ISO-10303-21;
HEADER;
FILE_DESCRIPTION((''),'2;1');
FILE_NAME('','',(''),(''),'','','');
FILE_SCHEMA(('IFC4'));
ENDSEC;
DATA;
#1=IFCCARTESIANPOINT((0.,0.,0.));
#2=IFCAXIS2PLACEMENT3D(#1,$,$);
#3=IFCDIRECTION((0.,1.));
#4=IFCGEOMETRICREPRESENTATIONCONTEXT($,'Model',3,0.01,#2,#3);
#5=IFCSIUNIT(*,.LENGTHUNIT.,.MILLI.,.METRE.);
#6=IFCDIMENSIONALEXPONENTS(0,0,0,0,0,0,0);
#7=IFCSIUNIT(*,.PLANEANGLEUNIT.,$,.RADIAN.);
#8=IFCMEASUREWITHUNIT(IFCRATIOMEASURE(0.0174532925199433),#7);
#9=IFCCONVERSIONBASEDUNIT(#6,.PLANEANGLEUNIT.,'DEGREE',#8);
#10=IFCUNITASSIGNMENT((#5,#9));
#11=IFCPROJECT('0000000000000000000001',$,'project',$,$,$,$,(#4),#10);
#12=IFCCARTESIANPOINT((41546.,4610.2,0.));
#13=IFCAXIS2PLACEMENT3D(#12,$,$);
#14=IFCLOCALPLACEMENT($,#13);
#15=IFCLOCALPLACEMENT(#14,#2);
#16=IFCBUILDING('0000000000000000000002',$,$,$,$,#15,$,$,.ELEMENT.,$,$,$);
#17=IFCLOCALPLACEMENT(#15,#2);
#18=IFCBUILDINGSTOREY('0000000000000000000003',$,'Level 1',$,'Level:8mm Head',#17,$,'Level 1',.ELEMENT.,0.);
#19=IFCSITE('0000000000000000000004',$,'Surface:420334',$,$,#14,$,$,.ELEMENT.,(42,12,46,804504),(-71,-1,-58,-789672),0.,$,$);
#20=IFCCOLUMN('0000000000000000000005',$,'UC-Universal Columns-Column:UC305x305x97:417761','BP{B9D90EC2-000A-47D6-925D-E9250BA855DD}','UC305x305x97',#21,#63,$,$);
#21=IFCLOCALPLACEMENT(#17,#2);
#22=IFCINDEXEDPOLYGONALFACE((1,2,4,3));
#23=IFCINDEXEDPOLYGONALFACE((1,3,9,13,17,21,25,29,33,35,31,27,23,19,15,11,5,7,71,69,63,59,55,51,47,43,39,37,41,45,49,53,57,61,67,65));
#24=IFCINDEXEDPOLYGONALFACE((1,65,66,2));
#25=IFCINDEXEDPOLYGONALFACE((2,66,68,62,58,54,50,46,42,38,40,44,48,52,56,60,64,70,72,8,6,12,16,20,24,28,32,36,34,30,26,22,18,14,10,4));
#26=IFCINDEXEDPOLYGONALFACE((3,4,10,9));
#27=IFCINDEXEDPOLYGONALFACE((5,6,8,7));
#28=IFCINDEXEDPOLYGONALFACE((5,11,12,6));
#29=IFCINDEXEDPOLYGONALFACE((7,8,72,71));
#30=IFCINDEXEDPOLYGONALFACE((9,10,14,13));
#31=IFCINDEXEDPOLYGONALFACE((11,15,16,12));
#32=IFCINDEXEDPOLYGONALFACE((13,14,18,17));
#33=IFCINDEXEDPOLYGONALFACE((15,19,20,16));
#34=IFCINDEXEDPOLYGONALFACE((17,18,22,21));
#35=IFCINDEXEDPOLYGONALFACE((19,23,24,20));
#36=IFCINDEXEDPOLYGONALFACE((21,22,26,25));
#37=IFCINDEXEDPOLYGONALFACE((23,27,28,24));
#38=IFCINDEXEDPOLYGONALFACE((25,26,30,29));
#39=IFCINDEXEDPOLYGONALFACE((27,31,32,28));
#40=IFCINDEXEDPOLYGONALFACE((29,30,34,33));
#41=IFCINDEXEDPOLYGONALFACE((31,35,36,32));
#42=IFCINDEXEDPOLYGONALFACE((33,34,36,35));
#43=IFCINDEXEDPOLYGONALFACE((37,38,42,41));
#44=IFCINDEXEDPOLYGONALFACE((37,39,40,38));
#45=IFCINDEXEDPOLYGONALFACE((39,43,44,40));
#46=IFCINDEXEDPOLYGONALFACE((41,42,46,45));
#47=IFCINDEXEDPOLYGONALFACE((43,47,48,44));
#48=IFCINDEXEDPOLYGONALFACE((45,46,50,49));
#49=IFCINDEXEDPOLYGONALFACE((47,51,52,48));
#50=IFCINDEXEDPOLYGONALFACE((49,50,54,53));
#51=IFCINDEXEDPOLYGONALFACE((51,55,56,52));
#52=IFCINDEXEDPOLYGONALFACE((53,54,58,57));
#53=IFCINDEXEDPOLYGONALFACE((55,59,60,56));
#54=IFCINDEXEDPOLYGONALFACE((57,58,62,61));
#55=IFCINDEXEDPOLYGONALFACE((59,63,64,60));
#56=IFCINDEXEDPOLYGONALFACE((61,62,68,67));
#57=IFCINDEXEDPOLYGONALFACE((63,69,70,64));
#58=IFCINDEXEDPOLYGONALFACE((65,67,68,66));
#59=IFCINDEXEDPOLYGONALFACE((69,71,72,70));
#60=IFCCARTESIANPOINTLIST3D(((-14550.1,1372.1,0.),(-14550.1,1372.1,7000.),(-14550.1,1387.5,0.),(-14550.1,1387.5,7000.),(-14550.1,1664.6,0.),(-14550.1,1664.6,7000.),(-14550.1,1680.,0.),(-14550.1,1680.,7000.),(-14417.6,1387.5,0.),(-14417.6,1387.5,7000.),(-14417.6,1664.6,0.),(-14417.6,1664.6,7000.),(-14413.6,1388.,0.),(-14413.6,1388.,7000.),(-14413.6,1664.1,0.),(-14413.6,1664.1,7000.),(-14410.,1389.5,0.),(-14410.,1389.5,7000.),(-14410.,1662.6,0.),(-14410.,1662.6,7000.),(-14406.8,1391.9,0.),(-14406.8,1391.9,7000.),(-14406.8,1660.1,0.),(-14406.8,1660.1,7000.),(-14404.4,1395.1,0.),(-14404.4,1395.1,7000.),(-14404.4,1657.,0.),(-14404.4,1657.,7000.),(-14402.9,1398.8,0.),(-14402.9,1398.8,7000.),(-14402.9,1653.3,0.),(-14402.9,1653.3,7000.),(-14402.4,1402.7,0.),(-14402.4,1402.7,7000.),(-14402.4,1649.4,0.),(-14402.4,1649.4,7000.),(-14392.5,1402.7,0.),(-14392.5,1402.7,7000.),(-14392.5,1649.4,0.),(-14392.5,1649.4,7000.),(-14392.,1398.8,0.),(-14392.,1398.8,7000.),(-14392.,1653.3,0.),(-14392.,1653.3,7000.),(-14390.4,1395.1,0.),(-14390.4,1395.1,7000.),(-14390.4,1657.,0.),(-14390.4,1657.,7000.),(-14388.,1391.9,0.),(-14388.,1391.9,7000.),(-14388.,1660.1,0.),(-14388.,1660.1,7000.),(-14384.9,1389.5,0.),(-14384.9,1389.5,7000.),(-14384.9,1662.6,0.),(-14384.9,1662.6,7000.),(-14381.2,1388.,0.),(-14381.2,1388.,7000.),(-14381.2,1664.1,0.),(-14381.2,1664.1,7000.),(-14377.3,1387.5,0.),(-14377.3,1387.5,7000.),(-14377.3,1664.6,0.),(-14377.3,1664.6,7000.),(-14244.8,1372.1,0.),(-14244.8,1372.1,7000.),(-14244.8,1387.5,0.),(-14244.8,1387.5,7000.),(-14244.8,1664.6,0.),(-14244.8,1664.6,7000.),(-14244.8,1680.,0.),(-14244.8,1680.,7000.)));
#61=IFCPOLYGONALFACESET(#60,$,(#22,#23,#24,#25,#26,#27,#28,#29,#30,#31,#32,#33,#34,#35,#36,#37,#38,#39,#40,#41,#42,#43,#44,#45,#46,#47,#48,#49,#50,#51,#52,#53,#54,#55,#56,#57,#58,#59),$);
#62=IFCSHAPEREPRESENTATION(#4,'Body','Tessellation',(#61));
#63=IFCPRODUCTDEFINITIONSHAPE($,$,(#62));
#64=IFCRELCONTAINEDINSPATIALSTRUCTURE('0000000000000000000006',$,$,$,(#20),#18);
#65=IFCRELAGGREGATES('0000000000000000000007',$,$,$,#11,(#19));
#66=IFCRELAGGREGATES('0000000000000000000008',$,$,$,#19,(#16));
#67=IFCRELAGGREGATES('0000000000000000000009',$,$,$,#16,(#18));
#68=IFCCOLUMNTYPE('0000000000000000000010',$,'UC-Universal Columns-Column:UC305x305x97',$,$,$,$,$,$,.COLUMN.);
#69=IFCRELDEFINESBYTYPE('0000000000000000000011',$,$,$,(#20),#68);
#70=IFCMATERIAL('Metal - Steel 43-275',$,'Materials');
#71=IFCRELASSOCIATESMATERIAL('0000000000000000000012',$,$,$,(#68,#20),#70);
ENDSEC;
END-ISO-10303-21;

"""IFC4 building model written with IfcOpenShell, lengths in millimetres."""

from ifc_helpers import new_model, entity, si_unit, converted_unit, direction, frame, origin, origin_2d, place, context, project, spatial, i_section, extrude, material, type_object, element, save


model = new_model("IFC4")

# Units and contexts
model_context = context("Model", 3, precision=0.01, world=origin(), true_north=direction((0.0, 1.0)))
ifc_project = project(units=[si_unit("LENGTHUNIT", "METRE", prefix="MILLI"), converted_unit("PLANEANGLEUNIT", "DEGREE", entity("IfcRatioMeasure", 0.0174532925199433), si_unit("PLANEANGLEUNIT", "RADIAN"), dimensions=[0, 0, 0, 0, 0, 0, 0])], contexts=[model_context])

# Site, building, storey
site_placement = place(None, frame((41546.0, 4610.2, 0.0)))
site = spatial("IfcSite", under=ifc_project, at=site_placement, Name="Surface:420334", CompositionType="ELEMENT", RefLatitude=(42, 12, 46, 804504), RefLongitude=(-71, -1, -58, -789672), RefElevation=0.0)
building_placement = place(site_placement, origin())
building = spatial("IfcBuilding", under=site, at=building_placement, CompositionType="ELEMENT")
storey_placement = place(building_placement, origin())
storey = spatial("IfcBuildingStorey", under=building, at=storey_placement, Name="Level 1", ObjectType="Level:8mm Head", LongName="Level 1", CompositionType="ELEMENT", Elevation=0.0)

# Column
ifc_material = material(Name="Metal - Steel 43-275", Category="Materials")
column_type = type_object("IfcColumnType", Name="UC-Universal Columns-Column:UC305x305x97", PredefinedType="COLUMN", material=ifc_material)
column_placement = place(storey_placement, frame((-14397.4, 1526.0, 7000.0)))
element("IfcColumn", 1, at=column_placement, inside=storey, type_object=column_type, material=ifc_material, Name="UC-Universal Columns-Column:UC305x305x97:417761", Description="BP{B9D90EC2-000A-47D6-925D-E9250BA855DD}", ObjectType="UC305x305x97", context=model_context, shape_type="SweptSolid", body=[
    extrude(i_section(OverallWidth=305.3, OverallDepth=307.9, WebThickness=9.9, FlangeThickness=15.4, FilletRadius=15.2, at=origin_2d()), origin(), (0.0, 0.0, -1.0), 7000.0),
])

save(model, "model.ifc")
